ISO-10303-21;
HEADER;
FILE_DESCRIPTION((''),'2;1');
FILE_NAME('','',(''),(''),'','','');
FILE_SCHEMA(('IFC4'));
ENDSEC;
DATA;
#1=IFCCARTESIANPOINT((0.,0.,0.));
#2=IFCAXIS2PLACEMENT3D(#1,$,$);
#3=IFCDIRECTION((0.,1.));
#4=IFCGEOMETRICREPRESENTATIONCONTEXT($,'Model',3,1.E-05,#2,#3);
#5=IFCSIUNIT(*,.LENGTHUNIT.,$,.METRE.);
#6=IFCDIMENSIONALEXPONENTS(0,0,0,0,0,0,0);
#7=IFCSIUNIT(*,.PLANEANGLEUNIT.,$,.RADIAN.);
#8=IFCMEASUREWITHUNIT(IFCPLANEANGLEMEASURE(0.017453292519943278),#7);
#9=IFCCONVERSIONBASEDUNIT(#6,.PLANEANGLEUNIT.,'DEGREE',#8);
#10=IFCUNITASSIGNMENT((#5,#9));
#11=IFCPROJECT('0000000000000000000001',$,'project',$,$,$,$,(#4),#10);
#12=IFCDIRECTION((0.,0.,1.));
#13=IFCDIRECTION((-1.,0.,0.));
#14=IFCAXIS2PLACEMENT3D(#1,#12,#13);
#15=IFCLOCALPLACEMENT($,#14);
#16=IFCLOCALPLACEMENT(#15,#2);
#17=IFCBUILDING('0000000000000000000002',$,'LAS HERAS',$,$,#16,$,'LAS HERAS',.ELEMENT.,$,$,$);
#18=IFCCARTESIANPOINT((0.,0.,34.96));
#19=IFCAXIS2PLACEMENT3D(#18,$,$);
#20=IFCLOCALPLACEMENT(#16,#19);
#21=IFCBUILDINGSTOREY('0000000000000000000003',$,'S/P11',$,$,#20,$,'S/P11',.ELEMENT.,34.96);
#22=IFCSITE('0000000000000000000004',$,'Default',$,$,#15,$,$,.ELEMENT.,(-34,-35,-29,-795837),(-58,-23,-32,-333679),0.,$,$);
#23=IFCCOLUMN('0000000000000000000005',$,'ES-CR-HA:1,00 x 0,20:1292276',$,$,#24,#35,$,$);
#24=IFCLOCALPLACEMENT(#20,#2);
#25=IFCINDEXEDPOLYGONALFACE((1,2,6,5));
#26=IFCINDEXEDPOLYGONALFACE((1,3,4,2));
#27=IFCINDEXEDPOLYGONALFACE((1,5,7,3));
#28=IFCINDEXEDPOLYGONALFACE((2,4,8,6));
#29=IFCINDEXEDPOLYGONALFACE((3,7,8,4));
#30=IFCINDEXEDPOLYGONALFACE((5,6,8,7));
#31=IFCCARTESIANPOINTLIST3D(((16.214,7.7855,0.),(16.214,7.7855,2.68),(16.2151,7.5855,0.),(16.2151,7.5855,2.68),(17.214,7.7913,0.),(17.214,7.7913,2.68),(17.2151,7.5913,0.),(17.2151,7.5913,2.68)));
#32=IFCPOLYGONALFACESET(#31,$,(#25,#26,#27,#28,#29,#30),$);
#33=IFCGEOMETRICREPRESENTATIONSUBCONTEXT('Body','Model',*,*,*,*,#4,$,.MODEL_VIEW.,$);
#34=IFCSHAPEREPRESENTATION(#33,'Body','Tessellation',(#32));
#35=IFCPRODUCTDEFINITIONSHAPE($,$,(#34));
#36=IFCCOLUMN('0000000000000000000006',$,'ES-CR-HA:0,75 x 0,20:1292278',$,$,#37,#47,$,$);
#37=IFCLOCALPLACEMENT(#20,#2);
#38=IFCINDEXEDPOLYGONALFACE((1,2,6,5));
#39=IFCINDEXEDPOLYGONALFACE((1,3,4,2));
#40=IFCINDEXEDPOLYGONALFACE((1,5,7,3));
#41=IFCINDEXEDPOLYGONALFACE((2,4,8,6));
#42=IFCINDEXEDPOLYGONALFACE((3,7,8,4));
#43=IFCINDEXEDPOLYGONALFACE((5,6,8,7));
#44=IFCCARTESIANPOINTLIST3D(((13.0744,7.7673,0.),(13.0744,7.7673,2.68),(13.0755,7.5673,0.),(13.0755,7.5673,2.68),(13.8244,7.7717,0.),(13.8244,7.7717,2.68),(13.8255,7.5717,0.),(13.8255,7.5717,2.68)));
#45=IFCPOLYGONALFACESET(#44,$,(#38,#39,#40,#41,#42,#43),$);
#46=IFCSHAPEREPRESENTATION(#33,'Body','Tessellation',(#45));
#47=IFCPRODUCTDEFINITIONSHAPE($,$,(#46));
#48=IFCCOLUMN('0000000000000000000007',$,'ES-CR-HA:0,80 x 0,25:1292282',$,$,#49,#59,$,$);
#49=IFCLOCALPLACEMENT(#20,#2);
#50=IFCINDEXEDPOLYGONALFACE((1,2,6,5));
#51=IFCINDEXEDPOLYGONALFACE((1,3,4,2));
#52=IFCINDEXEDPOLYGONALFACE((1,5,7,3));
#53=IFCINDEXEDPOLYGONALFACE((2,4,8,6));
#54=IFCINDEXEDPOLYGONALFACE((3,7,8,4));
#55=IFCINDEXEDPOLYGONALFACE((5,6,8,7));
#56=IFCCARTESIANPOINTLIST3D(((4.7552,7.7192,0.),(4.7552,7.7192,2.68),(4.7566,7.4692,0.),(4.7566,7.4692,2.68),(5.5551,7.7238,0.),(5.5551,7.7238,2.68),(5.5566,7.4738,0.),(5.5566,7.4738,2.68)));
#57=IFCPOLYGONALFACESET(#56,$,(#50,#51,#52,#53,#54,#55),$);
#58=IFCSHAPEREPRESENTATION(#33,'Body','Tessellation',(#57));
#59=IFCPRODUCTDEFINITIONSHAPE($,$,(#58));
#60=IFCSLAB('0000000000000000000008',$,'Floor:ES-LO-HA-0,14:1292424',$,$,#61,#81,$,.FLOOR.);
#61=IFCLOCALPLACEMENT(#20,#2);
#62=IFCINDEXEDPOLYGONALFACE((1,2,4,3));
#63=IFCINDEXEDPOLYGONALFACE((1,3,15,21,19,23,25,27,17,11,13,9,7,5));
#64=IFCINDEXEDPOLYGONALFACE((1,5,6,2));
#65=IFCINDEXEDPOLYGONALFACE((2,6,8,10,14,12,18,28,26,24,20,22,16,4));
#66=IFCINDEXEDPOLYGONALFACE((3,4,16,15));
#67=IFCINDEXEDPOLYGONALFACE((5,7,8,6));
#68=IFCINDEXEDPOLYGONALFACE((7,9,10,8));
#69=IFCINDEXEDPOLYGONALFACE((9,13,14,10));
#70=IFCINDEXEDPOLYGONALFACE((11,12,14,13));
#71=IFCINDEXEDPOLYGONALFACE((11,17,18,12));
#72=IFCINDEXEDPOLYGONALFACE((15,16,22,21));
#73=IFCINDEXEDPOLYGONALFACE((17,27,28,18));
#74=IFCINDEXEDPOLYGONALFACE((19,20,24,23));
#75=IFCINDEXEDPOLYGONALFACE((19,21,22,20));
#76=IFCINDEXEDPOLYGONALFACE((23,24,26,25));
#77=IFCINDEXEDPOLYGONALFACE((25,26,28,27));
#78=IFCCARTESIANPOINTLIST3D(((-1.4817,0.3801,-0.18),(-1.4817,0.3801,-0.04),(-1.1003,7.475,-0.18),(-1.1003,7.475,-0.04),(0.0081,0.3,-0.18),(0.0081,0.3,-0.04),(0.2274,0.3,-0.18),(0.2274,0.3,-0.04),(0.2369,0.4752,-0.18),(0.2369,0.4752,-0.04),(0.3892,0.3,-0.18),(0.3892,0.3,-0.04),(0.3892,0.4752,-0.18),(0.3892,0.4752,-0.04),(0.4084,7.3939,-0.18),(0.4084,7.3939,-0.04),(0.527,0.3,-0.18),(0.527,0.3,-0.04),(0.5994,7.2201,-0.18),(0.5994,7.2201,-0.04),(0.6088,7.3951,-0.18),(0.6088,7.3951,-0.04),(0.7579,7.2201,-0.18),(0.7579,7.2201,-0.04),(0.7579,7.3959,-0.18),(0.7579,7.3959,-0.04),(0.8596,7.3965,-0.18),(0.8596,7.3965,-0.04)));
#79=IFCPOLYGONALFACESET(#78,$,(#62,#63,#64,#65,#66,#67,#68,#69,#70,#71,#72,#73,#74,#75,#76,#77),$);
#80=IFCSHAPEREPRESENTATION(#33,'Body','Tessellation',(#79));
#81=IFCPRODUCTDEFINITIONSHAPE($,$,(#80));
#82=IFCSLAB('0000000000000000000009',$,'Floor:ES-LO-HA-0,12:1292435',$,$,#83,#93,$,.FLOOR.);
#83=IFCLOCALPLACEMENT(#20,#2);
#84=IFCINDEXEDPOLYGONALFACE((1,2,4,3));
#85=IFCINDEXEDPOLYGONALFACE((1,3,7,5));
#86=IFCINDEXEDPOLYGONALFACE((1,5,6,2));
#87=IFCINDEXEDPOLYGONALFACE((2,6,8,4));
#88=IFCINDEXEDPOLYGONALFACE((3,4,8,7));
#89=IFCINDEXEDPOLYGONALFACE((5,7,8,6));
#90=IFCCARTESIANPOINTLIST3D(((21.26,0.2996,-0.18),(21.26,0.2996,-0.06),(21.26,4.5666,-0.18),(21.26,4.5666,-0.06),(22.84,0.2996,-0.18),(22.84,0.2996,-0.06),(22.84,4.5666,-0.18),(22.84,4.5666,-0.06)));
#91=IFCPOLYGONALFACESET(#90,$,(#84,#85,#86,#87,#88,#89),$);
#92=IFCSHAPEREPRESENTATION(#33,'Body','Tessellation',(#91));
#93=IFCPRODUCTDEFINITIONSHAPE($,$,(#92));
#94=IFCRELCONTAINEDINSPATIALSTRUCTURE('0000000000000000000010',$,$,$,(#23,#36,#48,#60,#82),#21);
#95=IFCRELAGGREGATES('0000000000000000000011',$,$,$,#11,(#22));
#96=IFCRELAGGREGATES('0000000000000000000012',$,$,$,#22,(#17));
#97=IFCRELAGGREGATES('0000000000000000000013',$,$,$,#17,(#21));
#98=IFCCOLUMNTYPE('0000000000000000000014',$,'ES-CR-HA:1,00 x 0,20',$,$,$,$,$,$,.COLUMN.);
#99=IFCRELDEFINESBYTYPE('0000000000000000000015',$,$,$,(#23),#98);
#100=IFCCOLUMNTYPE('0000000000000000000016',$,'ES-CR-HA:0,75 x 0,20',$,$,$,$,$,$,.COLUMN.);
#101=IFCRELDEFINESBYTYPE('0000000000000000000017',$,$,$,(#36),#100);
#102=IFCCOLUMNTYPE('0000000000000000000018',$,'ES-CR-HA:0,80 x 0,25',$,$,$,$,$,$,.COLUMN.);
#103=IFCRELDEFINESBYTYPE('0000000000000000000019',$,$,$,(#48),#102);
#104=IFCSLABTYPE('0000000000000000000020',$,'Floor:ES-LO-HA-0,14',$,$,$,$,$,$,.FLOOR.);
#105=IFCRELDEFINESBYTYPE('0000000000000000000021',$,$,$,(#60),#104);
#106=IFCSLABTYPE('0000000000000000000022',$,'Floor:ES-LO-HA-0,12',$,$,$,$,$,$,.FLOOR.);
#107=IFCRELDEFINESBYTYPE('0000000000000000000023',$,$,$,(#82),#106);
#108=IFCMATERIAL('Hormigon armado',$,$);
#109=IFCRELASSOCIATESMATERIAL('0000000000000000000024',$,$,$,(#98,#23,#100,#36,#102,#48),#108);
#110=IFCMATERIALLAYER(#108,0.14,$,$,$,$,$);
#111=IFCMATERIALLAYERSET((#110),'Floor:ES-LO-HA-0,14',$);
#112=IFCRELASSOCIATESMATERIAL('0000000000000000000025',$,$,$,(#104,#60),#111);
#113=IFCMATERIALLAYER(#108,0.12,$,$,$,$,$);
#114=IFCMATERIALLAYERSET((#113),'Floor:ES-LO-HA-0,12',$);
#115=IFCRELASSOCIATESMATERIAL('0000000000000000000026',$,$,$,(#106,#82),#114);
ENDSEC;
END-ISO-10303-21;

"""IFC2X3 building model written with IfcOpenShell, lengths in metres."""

from ifc_helpers import new_model, entity, si_unit, converted_unit, direction, frame, frame_2d, origin, place, context, subcontext, project, spatial, polyline, rectangle, outline, extrude, source, transform, mapped, material, layer, layer_set, layer_usage, type_object, type_shapes, element, save


model = new_model("IFC2X3")

# Units and contexts
model_context = context("Model", 3, precision=1e-05, world=origin(), true_north=direction((0.0, 1.0)))
body_context = subcontext(model_context, "Body", "Model", "MODEL_VIEW")
ifc_project = project(units=[si_unit("LENGTHUNIT", "METRE"), converted_unit("PLANEANGLEUNIT", "DEGREE", entity("IfcPlaneAngleMeasure", 0.017453292519943278), si_unit("PLANEANGLEUNIT", "RADIAN"), dimensions=[0, 0, 0, 0, 0, 0, 0])], contexts=[model_context])

# Site, building, storey
site_placement = place(None, frame((0.0, 0.0, 0.0), z_axis=(0.0, 0.0, 1.0), x_axis=(-1.0, 0.0, 0.0)))
site = spatial("IfcSite", under=ifc_project, at=site_placement, Name="Default", CompositionType="ELEMENT", RefLatitude=(-34, -35, -29, -795837), RefLongitude=(-58, -23, -32, -333679), RefElevation=0.0)
building_placement = place(site_placement, origin())
building = spatial("IfcBuilding", under=site, at=building_placement, Name="LAS HERAS", LongName="LAS HERAS", CompositionType="ELEMENT")
storey_placement = place(building_placement, frame((0.0, 0.0, 34.96)))
storey = spatial("IfcBuildingStorey", under=building, at=storey_placement, Name="S/P11", LongName="S/P11", CompositionType="ELEMENT", Elevation=34.96)

# Columns
ifc_material = material(Name="Hormigon armado")
column_type_1 = type_object("IfcColumnType", Name="ES-CR-HA:1,00 x 0,20", PredefinedType="COLUMN", material=ifc_material)
shared_shape_1 = source(origin(), body_context, "Body", "SweptSolid", [
    extrude(rectangle(XDim=2.68, YDim=0.2, at=frame_2d((0.0, 0.0), x_axis=(1.0, 0.0))), frame((16.2146, 7.6855, 36.3), z_axis=(0.999983, 0.005788, 0.0), x_axis=(0.0, 0.0, 1.0)), (0.0, 0.0, 1.0), 1.0),
])
type_shapes(column_type_1, [shared_shape_1])
column_1_placement = place(storey_placement, frame((0.0, 0.0, -34.96)))
element("IfcColumn", 1, at=column_1_placement, inside=storey, type_object=column_type_1, material=ifc_material, Name="ES-CR-HA:1,00 x 0,20:1292276", context=body_context, shape_type="MappedRepresentation", body=[
    mapped(shared_shape_1, transform((0.0, 0.0, 0.0), scale=1.0)),
])
column_type_2 = type_object("IfcColumnType", Name="ES-CR-HA:0,75 x 0,20", PredefinedType="COLUMN", material=ifc_material)
shared_shape_2 = source(origin(), body_context, "Body", "SweptSolid", [
    extrude(rectangle(XDim=2.68, YDim=0.2, at=frame_2d((0.0, 0.0), x_axis=(1.0, 0.0))), frame((13.0749, 7.6673, 36.3), z_axis=(0.999983, 0.005788, 0.0), x_axis=(0.0, 0.0, 1.0)), (0.0, 0.0, 1.0), 0.75),
])
type_shapes(column_type_2, [shared_shape_2])
column_2_placement = place(storey_placement, frame((0.0, 0.0, -34.96)))
element("IfcColumn", 2, at=column_2_placement, inside=storey, type_object=column_type_2, material=ifc_material, Name="ES-CR-HA:0,75 x 0,20:1292278", context=body_context, shape_type="MappedRepresentation", body=[
    mapped(shared_shape_2, transform((0.0, 0.0, 0.0), scale=1.0)),
])
column_type_3 = type_object("IfcColumnType", Name="ES-CR-HA:0,80 x 0,25", PredefinedType="COLUMN", material=ifc_material)
shared_shape_3 = source(origin(), body_context, "Body", "SweptSolid", [
    extrude(rectangle(XDim=2.68, YDim=0.25, at=frame_2d((0.0, 0.0), x_axis=(1.0, 0.0))), frame((4.7559, 7.5942, 36.3), z_axis=(0.999983, 0.005788, 0.0), x_axis=(0.0, 0.0, 1.0)), (0.0, 0.0, 1.0), 0.8),
])
type_shapes(column_type_3, [shared_shape_3])
column_3_placement = place(storey_placement, frame((0.0, 0.0, -34.96)))
element("IfcColumn", 3, at=column_3_placement, inside=storey, type_object=column_type_3, material=ifc_material, Name="ES-CR-HA:0,80 x 0,25:1292282", context=body_context, shape_type="MappedRepresentation", body=[
    mapped(shared_shape_3, transform((0.0, 0.0, 0.0), scale=1.0)),
])

# Slab, openings
ifc_layer_1 = layer(ifc_material, 0.14)
ifc_layer_set_1 = layer_set([ifc_layer_1], Name="Floor:ES-LO-HA-0,14")
ifc_layer_usage_1 = layer_usage(ifc_layer_set_1, "AXIS3", "POSITIVE", 0.0)
slab_type_1 = type_object("IfcSlabType", Name="Floor:ES-LO-HA-0,14", PredefinedType="FLOOR", material=ifc_layer_set_1)
slab_1_placement = place(storey_placement, origin())
slab_1 = element("IfcSlab", 4, at=slab_1_placement, inside=storey, type_object=slab_type_1, material=ifc_layer_usage_1, Name="Floor:ES-LO-HA-0,14:1292424", PredefinedType="FLOOR", context=body_context, shape_type="SweptSolid", body=[
    extrude(outline(polyline([(-0.2993, -3.5591), (-0.1615, -3.5591), (-0.1615, -3.3839), (-0.0091, -3.3839), (0.0003, -3.5591), (0.2196, -3.5591), (1.7094, -3.479), (1.328, 3.6159), (-0.1807, 3.5348), (-0.3811, 3.536), (-0.3717, 3.3611), (-0.5302, 3.3611), (-0.5302, 3.5368), (-0.6319, 3.5374), (-0.2993, -3.5591)])), frame((0.2277, 3.8591, -0.04), z_axis=(0.0, 0.0, -1.0), x_axis=(-1.0, 0.0, 0.0)), (0.0, 0.0, 1.0), 0.14),
])
opening_1_placement = place(slab_1_placement, origin())
element("IfcOpeningElement", 5, at=opening_1_placement, cuts=slab_1, ObjectType="Opening", context=body_context, shape_type="SweptSolid", body=[
    extrude(outline(polyline([(0.2369, 0.4752), (0.2274, 0.3), (0.3892, 0.3), (0.3892, 0.4752), (0.2369, 0.4752)])), frame((0.0, 0.0, -0.04)), (0.0, 0.0, -1.0), 0.14),
])
opening_2_placement = place(slab_1_placement, origin())
element("IfcOpeningElement", 6, at=opening_2_placement, cuts=slab_1, ObjectType="Opening", context=body_context, shape_type="SweptSolid", body=[
    extrude(outline(polyline([(0.7579, 7.2201), (0.7579, 7.3959), (0.6088, 7.3951), (0.5994, 7.2201), (0.7579, 7.2201)])), frame((0.0, 0.0, -0.04)), (0.0, 0.0, -1.0), 0.14),
])

# Slab
ifc_layer_2 = layer(ifc_material, 0.12)
ifc_layer_set_2 = layer_set([ifc_layer_2], Name="Floor:ES-LO-HA-0,12")
ifc_layer_usage_2 = layer_usage(ifc_layer_set_2, "AXIS3", "POSITIVE", 0.0)
slab_type_2 = type_object("IfcSlabType", Name="Floor:ES-LO-HA-0,12", PredefinedType="FLOOR", material=ifc_layer_set_2)
slab_2_placement = place(storey_placement, origin())
element("IfcSlab", 7, at=slab_2_placement, inside=storey, type_object=slab_type_2, material=ifc_layer_usage_2, Name="Floor:ES-LO-HA-0,12:1292435", PredefinedType="FLOOR", context=body_context, shape_type="SweptSolid", body=[
    extrude(rectangle(XDim=4.2671, YDim=1.58, at=frame_2d((0.0, 0.0), x_axis=(1.0, 0.0))), frame((22.05, 2.4331, -0.06), z_axis=(0.0, 0.0, -1.0), x_axis=(0.0, 1.0, 0.0)), (0.0, 0.0, 1.0), 0.12),
])

save(model, "model.ifc")
